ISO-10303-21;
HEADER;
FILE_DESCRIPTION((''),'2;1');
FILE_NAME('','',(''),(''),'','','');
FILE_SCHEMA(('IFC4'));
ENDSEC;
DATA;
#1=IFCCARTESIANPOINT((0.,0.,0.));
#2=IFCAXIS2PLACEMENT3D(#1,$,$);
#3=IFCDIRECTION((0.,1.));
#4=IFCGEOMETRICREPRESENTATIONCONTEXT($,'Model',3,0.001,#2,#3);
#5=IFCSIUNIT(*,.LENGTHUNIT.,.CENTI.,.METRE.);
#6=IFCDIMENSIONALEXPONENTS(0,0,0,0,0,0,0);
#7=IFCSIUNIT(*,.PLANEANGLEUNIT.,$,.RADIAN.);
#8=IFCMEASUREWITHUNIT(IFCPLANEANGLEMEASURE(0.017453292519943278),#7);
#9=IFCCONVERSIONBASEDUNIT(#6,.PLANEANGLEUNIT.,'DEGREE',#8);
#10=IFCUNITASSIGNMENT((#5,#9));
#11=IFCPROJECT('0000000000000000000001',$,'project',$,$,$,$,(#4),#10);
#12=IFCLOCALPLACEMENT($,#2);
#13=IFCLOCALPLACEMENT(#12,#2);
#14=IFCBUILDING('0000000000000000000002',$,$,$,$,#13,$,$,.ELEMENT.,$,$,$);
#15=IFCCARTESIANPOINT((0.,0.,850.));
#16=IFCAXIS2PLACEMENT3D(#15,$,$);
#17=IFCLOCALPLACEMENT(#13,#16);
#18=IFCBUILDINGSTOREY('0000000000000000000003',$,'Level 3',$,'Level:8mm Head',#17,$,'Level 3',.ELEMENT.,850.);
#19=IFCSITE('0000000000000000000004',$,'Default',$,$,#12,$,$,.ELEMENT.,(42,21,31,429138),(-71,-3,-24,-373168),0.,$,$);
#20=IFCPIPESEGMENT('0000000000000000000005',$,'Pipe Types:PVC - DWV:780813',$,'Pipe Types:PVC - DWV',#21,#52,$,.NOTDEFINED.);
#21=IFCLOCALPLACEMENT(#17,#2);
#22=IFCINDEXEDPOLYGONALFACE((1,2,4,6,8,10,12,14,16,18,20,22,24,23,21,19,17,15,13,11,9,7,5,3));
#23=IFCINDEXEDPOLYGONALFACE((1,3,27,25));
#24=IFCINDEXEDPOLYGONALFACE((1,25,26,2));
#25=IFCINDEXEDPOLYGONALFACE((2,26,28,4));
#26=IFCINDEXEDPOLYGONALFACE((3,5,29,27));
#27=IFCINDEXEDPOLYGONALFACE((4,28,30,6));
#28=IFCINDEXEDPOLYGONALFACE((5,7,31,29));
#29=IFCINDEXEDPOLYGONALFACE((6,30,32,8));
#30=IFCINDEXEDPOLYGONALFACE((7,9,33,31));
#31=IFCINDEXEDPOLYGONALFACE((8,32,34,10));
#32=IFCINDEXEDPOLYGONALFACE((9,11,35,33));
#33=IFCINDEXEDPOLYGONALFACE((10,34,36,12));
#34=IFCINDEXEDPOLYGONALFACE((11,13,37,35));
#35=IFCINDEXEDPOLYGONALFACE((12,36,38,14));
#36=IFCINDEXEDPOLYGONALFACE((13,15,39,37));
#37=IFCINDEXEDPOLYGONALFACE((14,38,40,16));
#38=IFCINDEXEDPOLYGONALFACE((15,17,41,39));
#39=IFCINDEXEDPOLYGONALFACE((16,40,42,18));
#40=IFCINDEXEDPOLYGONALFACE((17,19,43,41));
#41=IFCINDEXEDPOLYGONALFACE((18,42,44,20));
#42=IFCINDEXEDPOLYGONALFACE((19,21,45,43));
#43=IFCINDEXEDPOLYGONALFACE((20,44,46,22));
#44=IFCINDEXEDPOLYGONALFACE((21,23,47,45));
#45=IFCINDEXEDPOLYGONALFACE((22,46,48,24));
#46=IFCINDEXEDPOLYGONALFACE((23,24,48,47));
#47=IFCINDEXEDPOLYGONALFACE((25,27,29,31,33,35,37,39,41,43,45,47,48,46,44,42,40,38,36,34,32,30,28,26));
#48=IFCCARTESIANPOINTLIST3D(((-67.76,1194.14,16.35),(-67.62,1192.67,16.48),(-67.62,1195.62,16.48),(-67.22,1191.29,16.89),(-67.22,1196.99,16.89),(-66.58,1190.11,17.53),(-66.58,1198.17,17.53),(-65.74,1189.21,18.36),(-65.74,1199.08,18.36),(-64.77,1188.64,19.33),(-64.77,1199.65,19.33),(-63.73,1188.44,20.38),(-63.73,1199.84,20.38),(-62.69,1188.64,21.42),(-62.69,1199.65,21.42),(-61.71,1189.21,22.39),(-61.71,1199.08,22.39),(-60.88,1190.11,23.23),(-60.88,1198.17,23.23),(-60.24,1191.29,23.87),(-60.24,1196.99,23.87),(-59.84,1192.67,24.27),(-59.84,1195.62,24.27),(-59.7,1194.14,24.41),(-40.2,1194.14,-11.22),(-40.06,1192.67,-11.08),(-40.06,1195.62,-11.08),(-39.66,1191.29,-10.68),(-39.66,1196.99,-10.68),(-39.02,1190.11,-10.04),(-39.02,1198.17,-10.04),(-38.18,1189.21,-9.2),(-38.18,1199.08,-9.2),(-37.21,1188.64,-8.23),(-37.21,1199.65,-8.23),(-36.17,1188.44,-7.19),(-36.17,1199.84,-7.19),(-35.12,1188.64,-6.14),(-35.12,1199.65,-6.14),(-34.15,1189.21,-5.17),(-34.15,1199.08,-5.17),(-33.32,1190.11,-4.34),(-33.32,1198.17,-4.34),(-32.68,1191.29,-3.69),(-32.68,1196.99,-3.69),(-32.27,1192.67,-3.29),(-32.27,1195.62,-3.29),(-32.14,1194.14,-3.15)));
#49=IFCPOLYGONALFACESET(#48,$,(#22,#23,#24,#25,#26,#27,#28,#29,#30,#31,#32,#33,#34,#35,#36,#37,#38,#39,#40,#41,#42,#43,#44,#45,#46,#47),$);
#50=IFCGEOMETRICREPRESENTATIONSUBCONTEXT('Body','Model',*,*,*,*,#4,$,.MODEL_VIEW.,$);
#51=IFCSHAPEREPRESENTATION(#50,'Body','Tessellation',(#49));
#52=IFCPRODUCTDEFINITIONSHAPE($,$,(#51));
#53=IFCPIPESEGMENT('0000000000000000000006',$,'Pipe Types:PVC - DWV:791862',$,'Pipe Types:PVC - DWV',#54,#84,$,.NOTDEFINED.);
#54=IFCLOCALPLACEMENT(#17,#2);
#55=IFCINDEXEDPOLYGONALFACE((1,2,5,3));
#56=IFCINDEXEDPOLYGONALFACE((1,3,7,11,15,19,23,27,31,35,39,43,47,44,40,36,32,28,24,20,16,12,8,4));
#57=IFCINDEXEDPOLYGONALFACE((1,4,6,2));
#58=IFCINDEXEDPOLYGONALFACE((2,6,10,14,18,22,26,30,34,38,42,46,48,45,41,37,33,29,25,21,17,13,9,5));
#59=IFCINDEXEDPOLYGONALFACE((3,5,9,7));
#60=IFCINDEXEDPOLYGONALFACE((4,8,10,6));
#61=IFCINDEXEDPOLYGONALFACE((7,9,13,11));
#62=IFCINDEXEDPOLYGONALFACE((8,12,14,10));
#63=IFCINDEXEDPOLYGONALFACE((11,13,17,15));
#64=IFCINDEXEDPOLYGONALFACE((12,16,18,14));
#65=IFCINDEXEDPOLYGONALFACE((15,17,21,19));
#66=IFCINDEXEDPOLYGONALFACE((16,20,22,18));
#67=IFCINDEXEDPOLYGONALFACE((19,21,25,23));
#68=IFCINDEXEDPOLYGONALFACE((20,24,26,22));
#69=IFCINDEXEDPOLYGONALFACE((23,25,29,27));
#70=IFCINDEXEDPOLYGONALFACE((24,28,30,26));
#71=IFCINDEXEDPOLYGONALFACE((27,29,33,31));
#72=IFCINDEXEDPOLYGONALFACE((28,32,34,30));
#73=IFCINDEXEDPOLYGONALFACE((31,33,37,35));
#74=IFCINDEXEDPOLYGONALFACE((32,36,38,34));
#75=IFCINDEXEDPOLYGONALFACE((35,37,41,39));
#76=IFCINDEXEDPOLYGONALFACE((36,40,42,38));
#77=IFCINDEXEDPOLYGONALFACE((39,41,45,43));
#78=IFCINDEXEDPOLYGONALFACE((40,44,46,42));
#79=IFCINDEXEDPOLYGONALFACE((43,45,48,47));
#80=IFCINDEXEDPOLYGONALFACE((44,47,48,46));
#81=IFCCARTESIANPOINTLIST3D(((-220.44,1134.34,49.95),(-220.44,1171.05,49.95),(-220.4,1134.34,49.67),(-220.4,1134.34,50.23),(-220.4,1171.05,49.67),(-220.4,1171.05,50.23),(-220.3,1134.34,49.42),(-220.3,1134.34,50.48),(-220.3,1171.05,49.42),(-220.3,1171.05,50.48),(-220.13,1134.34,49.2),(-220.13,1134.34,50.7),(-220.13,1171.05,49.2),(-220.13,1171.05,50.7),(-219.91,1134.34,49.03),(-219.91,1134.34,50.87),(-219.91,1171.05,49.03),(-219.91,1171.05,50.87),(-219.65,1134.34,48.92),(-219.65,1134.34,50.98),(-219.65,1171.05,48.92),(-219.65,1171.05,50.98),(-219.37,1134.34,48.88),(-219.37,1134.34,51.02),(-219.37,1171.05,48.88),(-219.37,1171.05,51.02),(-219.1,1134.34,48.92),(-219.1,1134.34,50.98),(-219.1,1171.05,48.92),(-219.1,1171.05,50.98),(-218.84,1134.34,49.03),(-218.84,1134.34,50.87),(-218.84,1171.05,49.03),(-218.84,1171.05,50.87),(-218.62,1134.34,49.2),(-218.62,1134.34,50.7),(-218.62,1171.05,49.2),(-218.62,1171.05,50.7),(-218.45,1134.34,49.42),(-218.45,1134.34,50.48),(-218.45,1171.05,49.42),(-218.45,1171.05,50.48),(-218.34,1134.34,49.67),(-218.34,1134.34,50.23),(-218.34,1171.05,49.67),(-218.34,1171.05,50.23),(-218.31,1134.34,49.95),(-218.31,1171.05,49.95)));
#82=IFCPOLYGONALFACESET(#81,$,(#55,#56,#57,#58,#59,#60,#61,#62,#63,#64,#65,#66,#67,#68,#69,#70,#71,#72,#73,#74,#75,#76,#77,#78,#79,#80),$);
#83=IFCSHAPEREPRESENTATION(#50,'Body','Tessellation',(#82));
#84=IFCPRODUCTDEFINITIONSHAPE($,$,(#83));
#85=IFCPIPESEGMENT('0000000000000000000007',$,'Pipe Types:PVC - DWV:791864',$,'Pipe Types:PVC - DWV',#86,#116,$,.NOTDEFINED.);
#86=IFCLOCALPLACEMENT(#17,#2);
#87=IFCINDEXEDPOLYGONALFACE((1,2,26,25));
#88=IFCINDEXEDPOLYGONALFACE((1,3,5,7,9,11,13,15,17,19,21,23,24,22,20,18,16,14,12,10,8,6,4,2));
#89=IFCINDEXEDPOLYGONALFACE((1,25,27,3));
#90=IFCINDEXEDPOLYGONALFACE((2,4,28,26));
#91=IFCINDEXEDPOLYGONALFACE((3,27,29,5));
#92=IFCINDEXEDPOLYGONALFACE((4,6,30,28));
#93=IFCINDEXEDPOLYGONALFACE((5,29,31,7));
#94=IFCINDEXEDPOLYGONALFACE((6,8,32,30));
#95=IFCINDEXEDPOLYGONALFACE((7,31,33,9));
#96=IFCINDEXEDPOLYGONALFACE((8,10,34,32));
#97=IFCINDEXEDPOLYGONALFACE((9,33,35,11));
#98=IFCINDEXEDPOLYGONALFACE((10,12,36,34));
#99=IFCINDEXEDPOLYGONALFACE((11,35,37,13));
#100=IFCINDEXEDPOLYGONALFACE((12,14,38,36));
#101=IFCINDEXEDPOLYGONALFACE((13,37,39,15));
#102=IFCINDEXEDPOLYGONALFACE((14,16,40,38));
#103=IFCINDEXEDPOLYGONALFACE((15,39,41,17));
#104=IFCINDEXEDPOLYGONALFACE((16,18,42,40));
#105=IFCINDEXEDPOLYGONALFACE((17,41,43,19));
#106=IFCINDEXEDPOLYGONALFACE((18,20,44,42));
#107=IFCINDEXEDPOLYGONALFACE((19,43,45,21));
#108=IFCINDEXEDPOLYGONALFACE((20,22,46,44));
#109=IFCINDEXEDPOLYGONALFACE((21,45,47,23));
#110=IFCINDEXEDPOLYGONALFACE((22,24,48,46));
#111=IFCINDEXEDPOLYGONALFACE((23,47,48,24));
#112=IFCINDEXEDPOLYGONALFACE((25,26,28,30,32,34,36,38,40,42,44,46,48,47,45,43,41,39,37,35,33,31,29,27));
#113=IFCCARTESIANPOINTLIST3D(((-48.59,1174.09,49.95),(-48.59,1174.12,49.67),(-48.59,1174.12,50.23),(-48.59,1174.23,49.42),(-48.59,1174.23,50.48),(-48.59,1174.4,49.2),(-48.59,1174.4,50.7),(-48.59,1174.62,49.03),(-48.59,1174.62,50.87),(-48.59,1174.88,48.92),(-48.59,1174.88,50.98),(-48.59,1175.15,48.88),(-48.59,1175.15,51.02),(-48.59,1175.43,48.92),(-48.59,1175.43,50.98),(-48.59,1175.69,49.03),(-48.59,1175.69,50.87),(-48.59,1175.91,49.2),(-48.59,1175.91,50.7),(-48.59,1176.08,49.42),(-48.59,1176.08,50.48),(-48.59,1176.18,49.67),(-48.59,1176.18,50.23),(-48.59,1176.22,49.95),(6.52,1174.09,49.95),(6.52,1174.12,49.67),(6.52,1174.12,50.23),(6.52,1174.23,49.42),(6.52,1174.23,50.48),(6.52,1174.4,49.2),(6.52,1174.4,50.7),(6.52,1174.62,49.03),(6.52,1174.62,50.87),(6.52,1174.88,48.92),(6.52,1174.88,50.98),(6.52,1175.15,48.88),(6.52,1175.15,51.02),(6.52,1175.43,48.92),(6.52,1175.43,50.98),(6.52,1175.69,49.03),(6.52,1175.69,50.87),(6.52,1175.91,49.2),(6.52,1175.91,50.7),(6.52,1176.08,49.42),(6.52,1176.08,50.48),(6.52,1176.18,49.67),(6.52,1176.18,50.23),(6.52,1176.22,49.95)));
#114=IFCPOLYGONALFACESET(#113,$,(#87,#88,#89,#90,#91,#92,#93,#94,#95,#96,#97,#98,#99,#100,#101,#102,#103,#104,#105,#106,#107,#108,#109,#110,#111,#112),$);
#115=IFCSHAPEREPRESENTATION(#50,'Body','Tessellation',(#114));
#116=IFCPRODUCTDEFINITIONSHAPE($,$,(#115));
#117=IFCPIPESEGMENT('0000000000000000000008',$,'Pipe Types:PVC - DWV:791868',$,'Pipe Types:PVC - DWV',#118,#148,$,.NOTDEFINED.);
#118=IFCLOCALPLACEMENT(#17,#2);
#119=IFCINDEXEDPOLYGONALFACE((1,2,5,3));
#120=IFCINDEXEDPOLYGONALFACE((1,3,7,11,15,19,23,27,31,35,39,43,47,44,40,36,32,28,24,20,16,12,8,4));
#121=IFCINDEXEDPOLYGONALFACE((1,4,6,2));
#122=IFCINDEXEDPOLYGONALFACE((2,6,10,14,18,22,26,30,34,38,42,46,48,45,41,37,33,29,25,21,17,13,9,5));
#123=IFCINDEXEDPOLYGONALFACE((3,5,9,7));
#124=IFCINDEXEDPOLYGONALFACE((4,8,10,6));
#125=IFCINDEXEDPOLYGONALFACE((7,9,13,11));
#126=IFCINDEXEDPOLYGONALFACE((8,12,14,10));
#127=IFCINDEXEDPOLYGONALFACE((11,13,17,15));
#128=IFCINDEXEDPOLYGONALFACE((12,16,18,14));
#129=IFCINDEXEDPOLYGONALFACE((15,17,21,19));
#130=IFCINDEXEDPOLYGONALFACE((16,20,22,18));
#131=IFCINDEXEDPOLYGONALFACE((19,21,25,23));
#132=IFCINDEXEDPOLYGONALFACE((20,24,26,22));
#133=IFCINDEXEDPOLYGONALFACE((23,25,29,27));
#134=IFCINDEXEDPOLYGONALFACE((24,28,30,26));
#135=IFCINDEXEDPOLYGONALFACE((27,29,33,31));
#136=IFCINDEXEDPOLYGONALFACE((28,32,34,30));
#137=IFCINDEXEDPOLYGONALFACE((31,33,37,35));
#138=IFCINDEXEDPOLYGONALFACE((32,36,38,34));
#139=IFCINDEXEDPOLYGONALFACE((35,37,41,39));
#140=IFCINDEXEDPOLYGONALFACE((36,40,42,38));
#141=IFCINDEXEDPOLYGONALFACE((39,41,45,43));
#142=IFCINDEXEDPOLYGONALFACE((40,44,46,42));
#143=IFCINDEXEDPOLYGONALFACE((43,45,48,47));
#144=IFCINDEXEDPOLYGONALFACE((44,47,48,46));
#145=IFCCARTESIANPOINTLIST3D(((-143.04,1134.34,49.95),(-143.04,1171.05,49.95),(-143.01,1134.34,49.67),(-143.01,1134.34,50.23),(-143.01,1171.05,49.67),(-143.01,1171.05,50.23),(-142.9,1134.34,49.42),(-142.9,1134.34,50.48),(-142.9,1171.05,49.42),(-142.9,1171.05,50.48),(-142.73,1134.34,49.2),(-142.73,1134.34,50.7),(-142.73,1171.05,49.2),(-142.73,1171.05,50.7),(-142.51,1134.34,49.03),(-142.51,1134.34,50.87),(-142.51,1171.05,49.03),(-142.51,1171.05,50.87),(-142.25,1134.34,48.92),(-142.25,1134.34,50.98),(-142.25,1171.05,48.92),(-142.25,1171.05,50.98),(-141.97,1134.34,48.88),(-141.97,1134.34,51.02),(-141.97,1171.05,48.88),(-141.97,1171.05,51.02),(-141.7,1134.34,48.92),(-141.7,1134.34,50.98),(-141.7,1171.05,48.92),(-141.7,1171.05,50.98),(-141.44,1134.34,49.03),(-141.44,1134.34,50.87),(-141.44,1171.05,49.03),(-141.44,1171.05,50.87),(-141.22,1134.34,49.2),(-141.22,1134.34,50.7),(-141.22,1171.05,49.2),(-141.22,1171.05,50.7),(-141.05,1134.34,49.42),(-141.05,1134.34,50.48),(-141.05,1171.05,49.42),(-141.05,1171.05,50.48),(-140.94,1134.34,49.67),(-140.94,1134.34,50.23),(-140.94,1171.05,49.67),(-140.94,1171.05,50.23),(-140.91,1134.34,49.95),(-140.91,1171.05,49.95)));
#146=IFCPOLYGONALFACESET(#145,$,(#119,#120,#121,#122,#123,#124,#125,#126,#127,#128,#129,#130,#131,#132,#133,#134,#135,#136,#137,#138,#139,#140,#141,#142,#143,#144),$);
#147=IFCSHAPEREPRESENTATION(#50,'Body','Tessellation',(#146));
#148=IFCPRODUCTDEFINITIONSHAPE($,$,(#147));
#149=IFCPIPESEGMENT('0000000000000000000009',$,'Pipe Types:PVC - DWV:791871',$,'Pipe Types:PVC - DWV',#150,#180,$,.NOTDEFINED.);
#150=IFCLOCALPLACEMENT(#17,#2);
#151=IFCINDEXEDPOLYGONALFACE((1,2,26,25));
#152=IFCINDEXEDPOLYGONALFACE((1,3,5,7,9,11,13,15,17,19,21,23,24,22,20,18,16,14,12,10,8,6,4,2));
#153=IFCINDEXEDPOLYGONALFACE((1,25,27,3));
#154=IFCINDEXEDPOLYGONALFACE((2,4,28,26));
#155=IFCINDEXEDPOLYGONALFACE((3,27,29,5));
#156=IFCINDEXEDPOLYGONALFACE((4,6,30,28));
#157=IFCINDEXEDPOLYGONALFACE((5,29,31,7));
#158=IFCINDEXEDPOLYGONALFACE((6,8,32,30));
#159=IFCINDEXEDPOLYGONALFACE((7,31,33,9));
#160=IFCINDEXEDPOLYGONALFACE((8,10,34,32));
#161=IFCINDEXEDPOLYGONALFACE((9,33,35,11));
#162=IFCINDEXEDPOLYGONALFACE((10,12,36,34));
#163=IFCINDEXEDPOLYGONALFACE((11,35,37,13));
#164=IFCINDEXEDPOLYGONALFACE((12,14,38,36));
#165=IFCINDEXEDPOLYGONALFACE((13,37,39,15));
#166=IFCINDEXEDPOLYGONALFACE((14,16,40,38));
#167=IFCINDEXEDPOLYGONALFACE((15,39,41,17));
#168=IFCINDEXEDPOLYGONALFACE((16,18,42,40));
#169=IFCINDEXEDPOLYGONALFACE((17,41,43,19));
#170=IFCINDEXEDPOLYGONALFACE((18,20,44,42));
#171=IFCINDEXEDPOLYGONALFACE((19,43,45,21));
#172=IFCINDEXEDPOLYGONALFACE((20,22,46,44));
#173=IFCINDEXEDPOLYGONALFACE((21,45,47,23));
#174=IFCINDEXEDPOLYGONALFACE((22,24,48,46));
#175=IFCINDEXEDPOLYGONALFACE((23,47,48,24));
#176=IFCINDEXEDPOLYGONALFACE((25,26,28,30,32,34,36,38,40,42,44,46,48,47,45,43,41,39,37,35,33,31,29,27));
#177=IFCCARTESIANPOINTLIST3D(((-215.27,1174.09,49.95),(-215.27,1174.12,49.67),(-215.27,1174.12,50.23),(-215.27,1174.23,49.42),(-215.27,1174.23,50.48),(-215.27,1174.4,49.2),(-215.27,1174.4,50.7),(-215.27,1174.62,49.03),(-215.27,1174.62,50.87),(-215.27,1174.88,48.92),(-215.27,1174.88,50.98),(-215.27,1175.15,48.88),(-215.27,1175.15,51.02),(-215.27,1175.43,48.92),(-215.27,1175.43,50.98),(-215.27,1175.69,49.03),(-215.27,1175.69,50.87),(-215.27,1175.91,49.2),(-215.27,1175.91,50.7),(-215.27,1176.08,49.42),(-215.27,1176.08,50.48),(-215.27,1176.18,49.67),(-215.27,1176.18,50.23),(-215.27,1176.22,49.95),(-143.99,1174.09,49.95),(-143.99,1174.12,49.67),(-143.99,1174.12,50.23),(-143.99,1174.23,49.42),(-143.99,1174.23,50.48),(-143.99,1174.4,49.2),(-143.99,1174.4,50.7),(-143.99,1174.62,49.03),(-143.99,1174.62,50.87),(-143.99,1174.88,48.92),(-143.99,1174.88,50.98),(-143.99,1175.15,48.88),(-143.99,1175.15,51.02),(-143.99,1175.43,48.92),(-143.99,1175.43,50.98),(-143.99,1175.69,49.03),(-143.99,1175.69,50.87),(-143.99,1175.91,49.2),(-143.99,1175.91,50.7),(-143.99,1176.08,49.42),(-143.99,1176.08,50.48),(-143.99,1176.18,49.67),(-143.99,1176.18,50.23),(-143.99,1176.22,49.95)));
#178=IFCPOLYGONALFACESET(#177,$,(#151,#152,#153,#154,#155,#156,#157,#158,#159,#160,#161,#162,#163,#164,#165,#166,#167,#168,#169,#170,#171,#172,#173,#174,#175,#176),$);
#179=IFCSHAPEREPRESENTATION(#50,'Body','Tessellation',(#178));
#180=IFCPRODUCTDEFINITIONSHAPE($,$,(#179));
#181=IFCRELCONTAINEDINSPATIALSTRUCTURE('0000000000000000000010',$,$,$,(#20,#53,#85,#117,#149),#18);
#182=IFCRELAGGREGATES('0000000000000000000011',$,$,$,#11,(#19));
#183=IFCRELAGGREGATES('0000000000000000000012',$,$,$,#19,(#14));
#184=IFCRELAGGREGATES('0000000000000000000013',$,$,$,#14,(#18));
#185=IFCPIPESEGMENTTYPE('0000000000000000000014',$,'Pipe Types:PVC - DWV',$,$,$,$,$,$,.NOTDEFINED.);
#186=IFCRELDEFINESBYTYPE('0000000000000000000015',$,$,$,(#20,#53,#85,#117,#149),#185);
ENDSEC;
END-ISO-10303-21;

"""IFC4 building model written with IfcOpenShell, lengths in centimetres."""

from ifc_helpers import new_model, entity, si_unit, converted_unit, direction, frame, origin, place, context, subcontext, project, spatial, arc, indexed_curve, outline, extrude, type_object, element, save


model = new_model("IFC4")

# Units and contexts
model_context = context("Model", 3, precision=0.001, world=origin(), true_north=direction((0.0, 1.0)))
body_context = subcontext(model_context, "Body", "Model", "MODEL_VIEW")
ifc_project = project(units=[si_unit("LENGTHUNIT", "METRE", prefix="CENTI"), converted_unit("PLANEANGLEUNIT", "DEGREE", entity("IfcPlaneAngleMeasure", 0.017453292519943278), si_unit("PLANEANGLEUNIT", "RADIAN"), dimensions=[0, 0, 0, 0, 0, 0, 0])], contexts=[model_context])

# Site, building, storey
site_placement = place(None, origin())
site = spatial("IfcSite", under=ifc_project, at=site_placement, Name="Default", CompositionType="ELEMENT", RefLatitude=(42, 21, 31, 429138), RefLongitude=(-71, -3, -24, -373168), RefElevation=0.0)
building_placement = place(site_placement, origin())
building = spatial("IfcBuilding", under=site, at=building_placement, CompositionType="ELEMENT")
storey_placement = place(building_placement, frame((0.0, 0.0, 850.0)))
storey = spatial("IfcBuildingStorey", under=building, at=storey_placement, Name="Level 3", ObjectType="Level:8mm Head", LongName="Level 3", CompositionType="ELEMENT", Elevation=850.0)

# Pipe segments
pipe_segment_type = type_object("IfcPipeSegmentType", Name="Pipe Types:PVC - DWV", PredefinedType="NOTDEFINED")
pipe_segment_1_placement = place(storey_placement, origin())
element("IfcPipeSegment", 1, at=pipe_segment_1_placement, inside=storey, type_object=pipe_segment_type, Name="Pipe Types:PVC - DWV:780813", ObjectType="Pipe Types:PVC - DWV", PredefinedType="NOTDEFINED", context=body_context, shape_type="SweptSolid", body=[
    extrude(outline(indexed_curve([(5.7, 0.0), (4.03, 4.03), (0.0, 5.7), (-4.03, 4.03), (-5.7, 0.0), (-4.03, -4.03), (0.0, -5.7), (4.03, -4.03)], segments=[arc(1, 2, 3), arc(3, 4, 5), arc(5, 6, 7), arc(7, 8, 1)], self_intersect=False)), frame((-36.17, 1194.14, -7.19), z_axis=(-0.707107, 0.0, 0.707107), x_axis=(0.0, -1.0, 0.0)), (0.0, 0.0, 1.0), 38.98),
])
pipe_segment_2_placement = place(storey_placement, origin())
element("IfcPipeSegment", 2, at=pipe_segment_2_placement, inside=storey, type_object=pipe_segment_type, Name="Pipe Types:PVC - DWV:791862", ObjectType="Pipe Types:PVC - DWV", PredefinedType="NOTDEFINED", context=body_context, shape_type="SweptSolid", body=[
    extrude(outline(indexed_curve([(1.07, 0.0), (0.75, 0.75), (0.0, 1.07), (-0.75, 0.75), (-1.07, 0.0), (-0.75, -0.75), (0.0, -1.07), (0.75, -0.75)], segments=[arc(1, 2, 3), arc(3, 4, 5), arc(5, 6, 7), arc(7, 8, 1)], self_intersect=False)), frame((-219.37, 1134.34, 49.95), z_axis=(0.0, 1.0, 0.0), x_axis=(1.0, 0.0, 0.0)), (0.0, 0.0, 1.0), 36.71),
])
pipe_segment_3_placement = place(storey_placement, origin())
element("IfcPipeSegment", 3, at=pipe_segment_3_placement, inside=storey, type_object=pipe_segment_type, Name="Pipe Types:PVC - DWV:791864", ObjectType="Pipe Types:PVC - DWV", PredefinedType="NOTDEFINED", context=body_context, shape_type="SweptSolid", body=[
    extrude(outline(indexed_curve([(1.07, 0.0), (0.75, 0.75), (0.0, 1.07), (-0.75, 0.75), (-1.07, 0.0), (-0.75, -0.75), (0.0, -1.07), (0.75, -0.75)], segments=[arc(1, 2, 3), arc(3, 4, 5), arc(5, 6, 7), arc(7, 8, 1)], self_intersect=False)), frame((-48.59, 1175.15, 49.95), z_axis=(1.0, 0.0, 0.0), x_axis=(0.0, -1.0, 0.0)), (0.0, 0.0, 1.0), 55.11),
])
pipe_segment_4_placement = place(storey_placement, origin())
element("IfcPipeSegment", 4, at=pipe_segment_4_placement, inside=storey, type_object=pipe_segment_type, Name="Pipe Types:PVC - DWV:791868", ObjectType="Pipe Types:PVC - DWV", PredefinedType="NOTDEFINED", context=body_context, shape_type="SweptSolid", body=[
    extrude(outline(indexed_curve([(1.07, 0.0), (0.75, 0.75), (0.0, 1.07), (-0.75, 0.75), (-1.07, 0.0), (-0.75, -0.75), (0.0, -1.07), (0.75, -0.75)], segments=[arc(1, 2, 3), arc(3, 4, 5), arc(5, 6, 7), arc(7, 8, 1)], self_intersect=False)), frame((-141.97, 1134.34, 49.95), z_axis=(0.0, 1.0, 0.0), x_axis=(-1.0, 0.0, 0.0)), (0.0, 0.0, 1.0), 36.71),
])
pipe_segment_5_placement = place(storey_placement, origin())
element("IfcPipeSegment", 5, at=pipe_segment_5_placement, inside=storey, type_object=pipe_segment_type, Name="Pipe Types:PVC - DWV:791871", ObjectType="Pipe Types:PVC - DWV", PredefinedType="NOTDEFINED", context=body_context, shape_type="SweptSolid", body=[
    extrude(outline(indexed_curve([(1.07, 0.0), (0.75, 0.75), (0.0, 1.07), (-0.75, 0.75), (-1.07, 0.0), (-0.75, -0.75), (0.0, -1.07), (0.75, -0.75)], segments=[arc(1, 2, 3), arc(3, 4, 5), arc(5, 6, 7), arc(7, 8, 1)], self_intersect=False)), frame((-215.27, 1175.15, 49.95), z_axis=(1.0, 0.0, 0.0), x_axis=(0.0, -1.0, 0.0)), (0.0, 0.0, 1.0), 71.29),
])

save(model, "model.ifc")
